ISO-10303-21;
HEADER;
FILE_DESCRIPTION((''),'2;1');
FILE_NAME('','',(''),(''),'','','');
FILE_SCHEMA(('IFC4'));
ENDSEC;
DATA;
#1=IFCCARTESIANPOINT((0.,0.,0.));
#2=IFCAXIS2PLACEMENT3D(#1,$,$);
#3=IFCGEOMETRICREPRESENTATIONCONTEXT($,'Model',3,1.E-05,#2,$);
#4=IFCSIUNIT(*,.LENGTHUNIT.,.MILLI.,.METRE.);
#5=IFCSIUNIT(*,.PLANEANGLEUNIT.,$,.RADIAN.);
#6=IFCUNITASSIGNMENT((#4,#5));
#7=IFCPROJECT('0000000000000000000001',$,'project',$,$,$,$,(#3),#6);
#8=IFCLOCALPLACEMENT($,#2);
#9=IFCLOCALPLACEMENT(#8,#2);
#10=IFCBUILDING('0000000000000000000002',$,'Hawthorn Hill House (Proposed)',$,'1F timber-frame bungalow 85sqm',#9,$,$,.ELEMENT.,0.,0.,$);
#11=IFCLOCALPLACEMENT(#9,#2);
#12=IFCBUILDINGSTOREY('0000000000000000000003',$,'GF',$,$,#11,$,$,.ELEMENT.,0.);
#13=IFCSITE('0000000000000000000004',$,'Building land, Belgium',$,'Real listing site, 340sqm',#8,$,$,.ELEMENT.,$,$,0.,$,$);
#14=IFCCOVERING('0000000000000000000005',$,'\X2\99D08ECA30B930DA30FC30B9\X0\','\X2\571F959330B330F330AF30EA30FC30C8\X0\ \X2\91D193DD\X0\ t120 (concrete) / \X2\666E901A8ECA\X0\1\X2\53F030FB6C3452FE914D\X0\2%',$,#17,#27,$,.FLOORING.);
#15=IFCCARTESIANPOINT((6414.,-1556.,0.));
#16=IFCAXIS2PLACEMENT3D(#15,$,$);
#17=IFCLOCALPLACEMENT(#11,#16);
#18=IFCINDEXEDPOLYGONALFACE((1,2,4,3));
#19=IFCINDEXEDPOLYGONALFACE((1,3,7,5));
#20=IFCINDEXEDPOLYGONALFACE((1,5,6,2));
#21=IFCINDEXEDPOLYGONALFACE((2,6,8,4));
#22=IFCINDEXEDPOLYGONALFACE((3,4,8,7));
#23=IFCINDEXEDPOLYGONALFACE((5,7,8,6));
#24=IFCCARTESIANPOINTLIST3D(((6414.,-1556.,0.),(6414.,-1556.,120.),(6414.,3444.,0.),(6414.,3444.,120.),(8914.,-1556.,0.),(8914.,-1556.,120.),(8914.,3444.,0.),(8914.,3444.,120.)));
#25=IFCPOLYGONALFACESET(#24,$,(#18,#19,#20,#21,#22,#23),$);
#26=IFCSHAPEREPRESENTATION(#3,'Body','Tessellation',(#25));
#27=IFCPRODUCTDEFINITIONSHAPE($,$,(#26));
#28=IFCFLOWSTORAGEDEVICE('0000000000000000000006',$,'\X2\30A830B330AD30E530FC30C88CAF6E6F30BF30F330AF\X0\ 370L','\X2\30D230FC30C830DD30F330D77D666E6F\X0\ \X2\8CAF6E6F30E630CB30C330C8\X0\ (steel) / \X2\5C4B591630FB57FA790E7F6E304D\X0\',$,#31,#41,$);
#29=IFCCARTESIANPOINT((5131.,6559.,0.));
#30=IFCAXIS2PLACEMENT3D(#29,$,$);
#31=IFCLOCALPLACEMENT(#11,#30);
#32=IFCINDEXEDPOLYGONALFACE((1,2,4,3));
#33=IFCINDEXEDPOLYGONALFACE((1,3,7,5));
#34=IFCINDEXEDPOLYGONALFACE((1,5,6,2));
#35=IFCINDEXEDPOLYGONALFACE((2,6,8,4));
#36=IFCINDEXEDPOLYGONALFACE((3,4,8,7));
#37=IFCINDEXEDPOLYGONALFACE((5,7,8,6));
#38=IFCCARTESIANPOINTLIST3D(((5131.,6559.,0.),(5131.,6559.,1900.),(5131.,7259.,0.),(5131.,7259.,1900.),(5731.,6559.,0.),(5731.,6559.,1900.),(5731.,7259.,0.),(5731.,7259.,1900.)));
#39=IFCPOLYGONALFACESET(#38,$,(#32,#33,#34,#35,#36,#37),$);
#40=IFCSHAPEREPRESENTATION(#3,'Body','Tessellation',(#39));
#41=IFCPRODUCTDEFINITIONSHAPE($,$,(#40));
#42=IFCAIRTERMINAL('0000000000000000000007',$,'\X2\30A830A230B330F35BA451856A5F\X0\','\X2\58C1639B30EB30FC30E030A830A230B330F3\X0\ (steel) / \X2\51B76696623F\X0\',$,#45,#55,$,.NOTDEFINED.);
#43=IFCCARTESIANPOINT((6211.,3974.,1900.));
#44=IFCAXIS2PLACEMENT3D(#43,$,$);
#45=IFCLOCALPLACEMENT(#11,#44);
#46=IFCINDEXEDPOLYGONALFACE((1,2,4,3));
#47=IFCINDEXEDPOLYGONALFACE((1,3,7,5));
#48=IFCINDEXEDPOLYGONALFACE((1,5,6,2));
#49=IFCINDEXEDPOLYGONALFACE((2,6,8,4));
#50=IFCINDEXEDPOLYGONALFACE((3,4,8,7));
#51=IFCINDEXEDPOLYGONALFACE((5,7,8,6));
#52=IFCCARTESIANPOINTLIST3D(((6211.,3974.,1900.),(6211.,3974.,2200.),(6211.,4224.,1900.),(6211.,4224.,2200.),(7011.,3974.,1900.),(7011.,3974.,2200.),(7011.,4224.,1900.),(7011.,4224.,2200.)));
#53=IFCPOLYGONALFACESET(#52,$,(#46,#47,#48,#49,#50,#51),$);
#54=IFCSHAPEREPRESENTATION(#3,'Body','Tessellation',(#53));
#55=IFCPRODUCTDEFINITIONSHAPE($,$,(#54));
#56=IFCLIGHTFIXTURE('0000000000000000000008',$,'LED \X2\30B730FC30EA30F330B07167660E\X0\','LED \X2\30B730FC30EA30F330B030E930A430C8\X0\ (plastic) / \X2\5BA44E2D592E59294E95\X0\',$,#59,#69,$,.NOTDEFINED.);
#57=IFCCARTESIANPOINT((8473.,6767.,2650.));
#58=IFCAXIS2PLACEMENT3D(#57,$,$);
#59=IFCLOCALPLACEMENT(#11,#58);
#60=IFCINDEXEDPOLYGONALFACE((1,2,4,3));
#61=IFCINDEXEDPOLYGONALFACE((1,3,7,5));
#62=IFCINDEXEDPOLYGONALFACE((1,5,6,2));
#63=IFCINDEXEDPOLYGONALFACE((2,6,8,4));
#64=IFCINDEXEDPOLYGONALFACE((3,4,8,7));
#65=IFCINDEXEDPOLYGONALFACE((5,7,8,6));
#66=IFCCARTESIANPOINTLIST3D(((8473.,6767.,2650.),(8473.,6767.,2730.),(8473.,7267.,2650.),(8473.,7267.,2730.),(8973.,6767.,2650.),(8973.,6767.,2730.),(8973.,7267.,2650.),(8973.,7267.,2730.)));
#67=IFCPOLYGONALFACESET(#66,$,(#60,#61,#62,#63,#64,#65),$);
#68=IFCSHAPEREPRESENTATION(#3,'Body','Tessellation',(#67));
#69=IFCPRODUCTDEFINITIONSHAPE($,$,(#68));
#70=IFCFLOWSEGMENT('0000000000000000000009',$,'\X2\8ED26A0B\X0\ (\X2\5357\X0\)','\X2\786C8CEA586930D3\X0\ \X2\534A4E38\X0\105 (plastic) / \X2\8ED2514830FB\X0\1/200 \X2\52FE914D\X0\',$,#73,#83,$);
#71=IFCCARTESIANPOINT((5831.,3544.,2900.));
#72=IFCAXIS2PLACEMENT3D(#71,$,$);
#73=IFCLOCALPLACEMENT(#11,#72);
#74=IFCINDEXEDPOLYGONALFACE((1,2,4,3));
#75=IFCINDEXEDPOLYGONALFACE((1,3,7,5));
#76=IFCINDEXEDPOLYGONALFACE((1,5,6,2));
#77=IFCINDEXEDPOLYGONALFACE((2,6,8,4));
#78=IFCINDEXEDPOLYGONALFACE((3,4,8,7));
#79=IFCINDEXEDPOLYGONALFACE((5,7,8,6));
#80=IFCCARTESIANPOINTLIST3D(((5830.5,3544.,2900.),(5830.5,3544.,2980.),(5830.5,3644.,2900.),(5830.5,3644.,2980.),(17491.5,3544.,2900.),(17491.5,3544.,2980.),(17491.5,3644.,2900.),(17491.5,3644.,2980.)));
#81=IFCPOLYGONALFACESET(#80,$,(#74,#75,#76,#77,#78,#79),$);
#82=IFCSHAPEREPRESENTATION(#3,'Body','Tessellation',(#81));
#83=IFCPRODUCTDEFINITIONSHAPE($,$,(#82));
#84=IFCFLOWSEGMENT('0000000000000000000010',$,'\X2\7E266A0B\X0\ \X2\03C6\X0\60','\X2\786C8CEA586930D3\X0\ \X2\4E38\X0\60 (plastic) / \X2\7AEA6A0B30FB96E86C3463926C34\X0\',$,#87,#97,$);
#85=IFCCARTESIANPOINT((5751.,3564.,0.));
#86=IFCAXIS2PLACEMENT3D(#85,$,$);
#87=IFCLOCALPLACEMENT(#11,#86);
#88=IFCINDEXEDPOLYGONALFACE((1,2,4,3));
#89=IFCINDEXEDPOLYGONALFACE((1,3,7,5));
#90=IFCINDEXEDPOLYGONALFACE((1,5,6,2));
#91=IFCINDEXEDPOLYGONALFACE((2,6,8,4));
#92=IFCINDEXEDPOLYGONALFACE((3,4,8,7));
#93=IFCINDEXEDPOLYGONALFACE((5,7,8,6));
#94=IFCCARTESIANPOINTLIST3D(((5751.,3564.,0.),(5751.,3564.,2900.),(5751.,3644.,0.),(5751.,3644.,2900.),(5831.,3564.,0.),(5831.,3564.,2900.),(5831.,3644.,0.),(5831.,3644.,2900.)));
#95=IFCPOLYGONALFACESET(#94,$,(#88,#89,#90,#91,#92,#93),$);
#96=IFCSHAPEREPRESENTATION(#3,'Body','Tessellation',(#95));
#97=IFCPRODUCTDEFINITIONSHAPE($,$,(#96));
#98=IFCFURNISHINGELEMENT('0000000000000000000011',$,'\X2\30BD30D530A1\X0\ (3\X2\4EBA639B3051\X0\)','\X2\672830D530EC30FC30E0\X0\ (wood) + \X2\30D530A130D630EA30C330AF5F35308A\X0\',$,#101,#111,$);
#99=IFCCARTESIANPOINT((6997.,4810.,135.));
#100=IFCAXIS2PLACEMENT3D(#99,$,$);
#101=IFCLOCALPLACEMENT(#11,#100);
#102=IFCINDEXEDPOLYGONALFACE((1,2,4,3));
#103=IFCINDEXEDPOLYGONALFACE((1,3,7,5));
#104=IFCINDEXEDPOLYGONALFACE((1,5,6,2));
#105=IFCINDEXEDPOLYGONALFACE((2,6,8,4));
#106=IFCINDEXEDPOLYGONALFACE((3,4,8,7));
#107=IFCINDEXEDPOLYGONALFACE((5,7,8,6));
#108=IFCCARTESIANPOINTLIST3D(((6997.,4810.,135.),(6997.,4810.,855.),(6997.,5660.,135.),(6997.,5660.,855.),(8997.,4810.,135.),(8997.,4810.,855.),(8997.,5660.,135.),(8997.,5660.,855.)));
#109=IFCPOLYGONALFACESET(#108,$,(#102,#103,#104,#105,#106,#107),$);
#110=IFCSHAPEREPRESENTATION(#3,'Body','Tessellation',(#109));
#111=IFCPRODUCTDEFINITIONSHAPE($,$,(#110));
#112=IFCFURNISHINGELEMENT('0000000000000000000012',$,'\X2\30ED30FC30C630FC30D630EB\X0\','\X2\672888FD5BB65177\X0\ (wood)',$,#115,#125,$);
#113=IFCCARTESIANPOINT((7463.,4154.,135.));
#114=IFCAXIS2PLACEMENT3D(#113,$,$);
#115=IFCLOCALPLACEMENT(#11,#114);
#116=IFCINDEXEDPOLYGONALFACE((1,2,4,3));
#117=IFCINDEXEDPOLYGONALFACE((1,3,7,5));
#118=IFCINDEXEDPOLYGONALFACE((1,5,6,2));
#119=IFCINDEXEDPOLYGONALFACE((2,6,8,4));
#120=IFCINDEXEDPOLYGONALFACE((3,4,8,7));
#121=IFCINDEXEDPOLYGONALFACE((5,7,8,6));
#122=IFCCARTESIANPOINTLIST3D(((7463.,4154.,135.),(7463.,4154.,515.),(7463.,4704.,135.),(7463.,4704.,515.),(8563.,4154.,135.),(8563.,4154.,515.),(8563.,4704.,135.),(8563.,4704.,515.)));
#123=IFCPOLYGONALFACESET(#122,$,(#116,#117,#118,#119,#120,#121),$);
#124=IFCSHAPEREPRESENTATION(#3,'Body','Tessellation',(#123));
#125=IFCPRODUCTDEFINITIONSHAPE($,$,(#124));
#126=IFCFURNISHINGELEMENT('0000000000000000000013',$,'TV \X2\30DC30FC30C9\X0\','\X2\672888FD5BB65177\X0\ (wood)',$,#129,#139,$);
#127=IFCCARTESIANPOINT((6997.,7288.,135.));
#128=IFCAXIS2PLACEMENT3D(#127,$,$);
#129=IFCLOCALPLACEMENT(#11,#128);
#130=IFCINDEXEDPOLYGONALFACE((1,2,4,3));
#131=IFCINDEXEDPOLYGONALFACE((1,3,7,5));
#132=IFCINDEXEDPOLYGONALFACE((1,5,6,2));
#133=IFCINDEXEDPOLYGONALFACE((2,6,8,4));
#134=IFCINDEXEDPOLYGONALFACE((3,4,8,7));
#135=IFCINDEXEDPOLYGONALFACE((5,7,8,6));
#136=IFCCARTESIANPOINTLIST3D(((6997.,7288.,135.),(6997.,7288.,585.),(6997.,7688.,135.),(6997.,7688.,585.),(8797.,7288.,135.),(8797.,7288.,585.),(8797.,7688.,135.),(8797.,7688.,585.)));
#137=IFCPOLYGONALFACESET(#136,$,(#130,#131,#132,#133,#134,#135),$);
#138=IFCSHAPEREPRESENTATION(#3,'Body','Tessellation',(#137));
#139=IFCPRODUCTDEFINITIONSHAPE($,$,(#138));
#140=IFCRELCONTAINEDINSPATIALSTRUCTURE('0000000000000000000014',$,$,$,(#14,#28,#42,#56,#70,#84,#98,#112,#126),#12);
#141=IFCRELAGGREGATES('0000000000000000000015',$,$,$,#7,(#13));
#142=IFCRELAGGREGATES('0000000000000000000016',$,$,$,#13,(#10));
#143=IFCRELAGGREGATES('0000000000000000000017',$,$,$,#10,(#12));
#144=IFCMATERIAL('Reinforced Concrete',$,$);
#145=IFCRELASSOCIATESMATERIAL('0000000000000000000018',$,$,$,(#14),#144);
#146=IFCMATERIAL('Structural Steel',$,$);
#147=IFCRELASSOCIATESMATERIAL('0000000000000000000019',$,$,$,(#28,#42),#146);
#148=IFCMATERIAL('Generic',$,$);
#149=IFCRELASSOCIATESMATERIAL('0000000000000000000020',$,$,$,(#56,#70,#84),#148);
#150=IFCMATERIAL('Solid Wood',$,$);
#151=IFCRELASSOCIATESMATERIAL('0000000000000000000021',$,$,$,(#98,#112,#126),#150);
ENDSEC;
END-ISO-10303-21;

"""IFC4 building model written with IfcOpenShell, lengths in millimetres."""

from ifc_helpers import new_model, si_unit, frame, frame_2d, origin, place, context, project, spatial, rectangle, extrude, material, element, save


model = new_model("IFC4")

# Units and contexts
model_context = context("Model", 3, precision=1e-05, world=origin())
ifc_project = project(units=[si_unit("LENGTHUNIT", "METRE", prefix="MILLI"), si_unit("PLANEANGLEUNIT", "RADIAN")], contexts=[model_context])

# Site, building, storey
site_placement = place(None, origin())
site = spatial("IfcSite", under=ifc_project, at=site_placement, Name="Building land, Belgium", ObjectType="Real listing site, 340sqm", CompositionType="ELEMENT", RefElevation=0.0)
building_placement = place(site_placement, origin())
building = spatial("IfcBuilding", under=site, at=building_placement, Name="Hawthorn Hill House (Proposed)", ObjectType="1F timber-frame bungalow 85sqm", CompositionType="ELEMENT", ElevationOfRefHeight=0.0, ElevationOfTerrain=0.0)
storey_placement = place(building_placement, origin())
storey = spatial("IfcBuildingStorey", under=building, at=storey_placement, Name="GF", CompositionType="ELEMENT", Elevation=0.0)

# Shared definitions
ifc_material_1 = material(Name="Solid Wood")

# Shared definitions
ifc_material_2 = material(Name="Reinforced Concrete")

# Shared definitions
ifc_material_3 = material(Name="Structural Steel")

# Covering
ifc_material_4 = material(Name="Generic")
covering_1_placement = place(storey_placement, frame((6414.0, -1556.0, 0.0)))
element("IfcCovering", 1, at=covering_1_placement, inside=storey, material=ifc_material_2, Name="駐車スペース", Description="土間コンクリート 金鏝 t120 (concrete) / 普通車1台・水勾配2%", PredefinedType="FLOORING", context=model_context, shape_type="SweptSolid", body=[
    extrude(rectangle(XDim=2500.0, YDim=5000.0, at=frame_2d((1250.0, 2500.0))), frame((6414.0, -1556.0, 0.0)), (0.0, 0.0, 1.0), 120.0),
])

# Flow storage device
flow_storage_device_placement = place(storey_placement, frame((5131.0, 6559.0, 0.0)))
element("IfcFlowStorageDevice", 2, at=flow_storage_device_placement, inside=storey, material=ifc_material_3, Name="エコキュート貯湯タンク 370L", Description="ヒートポンプ給湯 貯湯ユニット (steel) / 屋外・基礎置き", context=model_context, shape_type="SweptSolid", body=[
    extrude(rectangle(XDim=600.0, YDim=700.0, at=frame_2d((300.0, 350.0))), frame((5131.0, 6559.0, 0.0)), (0.0, 0.0, 1.0), 1900.0),
])

# Air terminal
air_terminal_placement = place(storey_placement, frame((6211.0, 3974.0, 1900.0)))
element("IfcAirTerminal", 3, at=air_terminal_placement, inside=storey, material=ifc_material_3, Name="エアコン室内機", Description="壁掛ルームエアコン (steel) / 冷暖房", PredefinedType="NOTDEFINED", context=model_context, shape_type="SweptSolid", body=[
    extrude(rectangle(XDim=800.0, YDim=250.0, at=frame_2d((400.0, 125.0))), frame((6211.0, 3974.0, 1900.0)), (0.0, 0.0, 1.0), 300.0),
])

# Light fixture
light_fixture_placement = place(storey_placement, frame((8473.0, 6767.0, 2650.0)))
element("IfcLightFixture", 4, at=light_fixture_placement, inside=storey, material=ifc_material_4, Name="LED シーリング照明", Description="LED シーリングライト (plastic) / 室中央天井", PredefinedType="NOTDEFINED", context=model_context, shape_type="SweptSolid", body=[
    extrude(rectangle(XDim=500.0, YDim=500.0, at=frame_2d((250.0, 250.0))), frame((8473.0, 6767.0, 2650.0)), (0.0, 0.0, 1.0), 80.0),
])

# Flow segments
flow_segment_1_placement = place(storey_placement, frame((5831.0, 3544.0, 2900.0)))
element("IfcFlowSegment", 5, at=flow_segment_1_placement, inside=storey, material=ifc_material_4, Name="軒樋 (南)", Description="硬質塩ビ 半丸105 (plastic) / 軒先・1/200 勾配", context=model_context, shape_type="SweptSolid", body=[
    extrude(rectangle(XDim=11661.0, YDim=100.0, at=frame_2d((5830.0, 50.0))), frame((5831.0, 3544.0, 2900.0)), (0.0, 0.0, 1.0), 80.0),
])
flow_segment_2_placement = place(storey_placement, frame((5751.0, 3564.0, 0.0)))
element("IfcFlowSegment", 6, at=flow_segment_2_placement, inside=storey, material=ifc_material_4, Name="縦樋 φ60", Description="硬質塩ビ 丸60 (plastic) / 竪樋・雨水排水", context=model_context, shape_type="SweptSolid", body=[
    extrude(rectangle(XDim=80.0, YDim=80.0, at=frame_2d((40.0, 40.0))), frame((5751.0, 3564.0, 0.0)), (0.0, 0.0, 1.0), 2900.0),
])

# Furnishing elements
furnishing_1_placement = place(storey_placement, frame((6997.0, 4810.0, 135.0)))
element("IfcFurnishingElement", 7, at=furnishing_1_placement, inside=storey, material=ifc_material_1, Name="ソファ (3人掛け)", Description="木フレーム (wood) + ファブリック張り", context=model_context, shape_type="SweptSolid", body=[
    extrude(rectangle(XDim=2000.0, YDim=850.0, at=frame_2d((1000.0, 425.0))), frame((6997.0, 4810.0, 135.0)), (0.0, 0.0, 1.0), 720.0),
])
furnishing_2_placement = place(storey_placement, frame((7463.0, 4154.0, 135.0)))
element("IfcFurnishingElement", 8, at=furnishing_2_placement, inside=storey, material=ifc_material_1, Name="ローテーブル", Description="木製家具 (wood)", context=model_context, shape_type="SweptSolid", body=[
    extrude(rectangle(XDim=1100.0, YDim=550.0, at=frame_2d((550.0, 275.0))), frame((7463.0, 4154.0, 135.0)), (0.0, 0.0, 1.0), 380.0),
])
furnishing_3_placement = place(storey_placement, frame((6997.0, 7288.0, 135.0)))
element("IfcFurnishingElement", 9, at=furnishing_3_placement, inside=storey, material=ifc_material_1, Name="TV ボード", Description="木製家具 (wood)", context=model_context, shape_type="SweptSolid", body=[
    extrude(rectangle(XDim=1800.0, YDim=400.0, at=frame_2d((900.0, 200.0))), frame((6997.0, 7288.0, 135.0)), (0.0, 0.0, 1.0), 450.0),
])

save(model, "model.ifc")
